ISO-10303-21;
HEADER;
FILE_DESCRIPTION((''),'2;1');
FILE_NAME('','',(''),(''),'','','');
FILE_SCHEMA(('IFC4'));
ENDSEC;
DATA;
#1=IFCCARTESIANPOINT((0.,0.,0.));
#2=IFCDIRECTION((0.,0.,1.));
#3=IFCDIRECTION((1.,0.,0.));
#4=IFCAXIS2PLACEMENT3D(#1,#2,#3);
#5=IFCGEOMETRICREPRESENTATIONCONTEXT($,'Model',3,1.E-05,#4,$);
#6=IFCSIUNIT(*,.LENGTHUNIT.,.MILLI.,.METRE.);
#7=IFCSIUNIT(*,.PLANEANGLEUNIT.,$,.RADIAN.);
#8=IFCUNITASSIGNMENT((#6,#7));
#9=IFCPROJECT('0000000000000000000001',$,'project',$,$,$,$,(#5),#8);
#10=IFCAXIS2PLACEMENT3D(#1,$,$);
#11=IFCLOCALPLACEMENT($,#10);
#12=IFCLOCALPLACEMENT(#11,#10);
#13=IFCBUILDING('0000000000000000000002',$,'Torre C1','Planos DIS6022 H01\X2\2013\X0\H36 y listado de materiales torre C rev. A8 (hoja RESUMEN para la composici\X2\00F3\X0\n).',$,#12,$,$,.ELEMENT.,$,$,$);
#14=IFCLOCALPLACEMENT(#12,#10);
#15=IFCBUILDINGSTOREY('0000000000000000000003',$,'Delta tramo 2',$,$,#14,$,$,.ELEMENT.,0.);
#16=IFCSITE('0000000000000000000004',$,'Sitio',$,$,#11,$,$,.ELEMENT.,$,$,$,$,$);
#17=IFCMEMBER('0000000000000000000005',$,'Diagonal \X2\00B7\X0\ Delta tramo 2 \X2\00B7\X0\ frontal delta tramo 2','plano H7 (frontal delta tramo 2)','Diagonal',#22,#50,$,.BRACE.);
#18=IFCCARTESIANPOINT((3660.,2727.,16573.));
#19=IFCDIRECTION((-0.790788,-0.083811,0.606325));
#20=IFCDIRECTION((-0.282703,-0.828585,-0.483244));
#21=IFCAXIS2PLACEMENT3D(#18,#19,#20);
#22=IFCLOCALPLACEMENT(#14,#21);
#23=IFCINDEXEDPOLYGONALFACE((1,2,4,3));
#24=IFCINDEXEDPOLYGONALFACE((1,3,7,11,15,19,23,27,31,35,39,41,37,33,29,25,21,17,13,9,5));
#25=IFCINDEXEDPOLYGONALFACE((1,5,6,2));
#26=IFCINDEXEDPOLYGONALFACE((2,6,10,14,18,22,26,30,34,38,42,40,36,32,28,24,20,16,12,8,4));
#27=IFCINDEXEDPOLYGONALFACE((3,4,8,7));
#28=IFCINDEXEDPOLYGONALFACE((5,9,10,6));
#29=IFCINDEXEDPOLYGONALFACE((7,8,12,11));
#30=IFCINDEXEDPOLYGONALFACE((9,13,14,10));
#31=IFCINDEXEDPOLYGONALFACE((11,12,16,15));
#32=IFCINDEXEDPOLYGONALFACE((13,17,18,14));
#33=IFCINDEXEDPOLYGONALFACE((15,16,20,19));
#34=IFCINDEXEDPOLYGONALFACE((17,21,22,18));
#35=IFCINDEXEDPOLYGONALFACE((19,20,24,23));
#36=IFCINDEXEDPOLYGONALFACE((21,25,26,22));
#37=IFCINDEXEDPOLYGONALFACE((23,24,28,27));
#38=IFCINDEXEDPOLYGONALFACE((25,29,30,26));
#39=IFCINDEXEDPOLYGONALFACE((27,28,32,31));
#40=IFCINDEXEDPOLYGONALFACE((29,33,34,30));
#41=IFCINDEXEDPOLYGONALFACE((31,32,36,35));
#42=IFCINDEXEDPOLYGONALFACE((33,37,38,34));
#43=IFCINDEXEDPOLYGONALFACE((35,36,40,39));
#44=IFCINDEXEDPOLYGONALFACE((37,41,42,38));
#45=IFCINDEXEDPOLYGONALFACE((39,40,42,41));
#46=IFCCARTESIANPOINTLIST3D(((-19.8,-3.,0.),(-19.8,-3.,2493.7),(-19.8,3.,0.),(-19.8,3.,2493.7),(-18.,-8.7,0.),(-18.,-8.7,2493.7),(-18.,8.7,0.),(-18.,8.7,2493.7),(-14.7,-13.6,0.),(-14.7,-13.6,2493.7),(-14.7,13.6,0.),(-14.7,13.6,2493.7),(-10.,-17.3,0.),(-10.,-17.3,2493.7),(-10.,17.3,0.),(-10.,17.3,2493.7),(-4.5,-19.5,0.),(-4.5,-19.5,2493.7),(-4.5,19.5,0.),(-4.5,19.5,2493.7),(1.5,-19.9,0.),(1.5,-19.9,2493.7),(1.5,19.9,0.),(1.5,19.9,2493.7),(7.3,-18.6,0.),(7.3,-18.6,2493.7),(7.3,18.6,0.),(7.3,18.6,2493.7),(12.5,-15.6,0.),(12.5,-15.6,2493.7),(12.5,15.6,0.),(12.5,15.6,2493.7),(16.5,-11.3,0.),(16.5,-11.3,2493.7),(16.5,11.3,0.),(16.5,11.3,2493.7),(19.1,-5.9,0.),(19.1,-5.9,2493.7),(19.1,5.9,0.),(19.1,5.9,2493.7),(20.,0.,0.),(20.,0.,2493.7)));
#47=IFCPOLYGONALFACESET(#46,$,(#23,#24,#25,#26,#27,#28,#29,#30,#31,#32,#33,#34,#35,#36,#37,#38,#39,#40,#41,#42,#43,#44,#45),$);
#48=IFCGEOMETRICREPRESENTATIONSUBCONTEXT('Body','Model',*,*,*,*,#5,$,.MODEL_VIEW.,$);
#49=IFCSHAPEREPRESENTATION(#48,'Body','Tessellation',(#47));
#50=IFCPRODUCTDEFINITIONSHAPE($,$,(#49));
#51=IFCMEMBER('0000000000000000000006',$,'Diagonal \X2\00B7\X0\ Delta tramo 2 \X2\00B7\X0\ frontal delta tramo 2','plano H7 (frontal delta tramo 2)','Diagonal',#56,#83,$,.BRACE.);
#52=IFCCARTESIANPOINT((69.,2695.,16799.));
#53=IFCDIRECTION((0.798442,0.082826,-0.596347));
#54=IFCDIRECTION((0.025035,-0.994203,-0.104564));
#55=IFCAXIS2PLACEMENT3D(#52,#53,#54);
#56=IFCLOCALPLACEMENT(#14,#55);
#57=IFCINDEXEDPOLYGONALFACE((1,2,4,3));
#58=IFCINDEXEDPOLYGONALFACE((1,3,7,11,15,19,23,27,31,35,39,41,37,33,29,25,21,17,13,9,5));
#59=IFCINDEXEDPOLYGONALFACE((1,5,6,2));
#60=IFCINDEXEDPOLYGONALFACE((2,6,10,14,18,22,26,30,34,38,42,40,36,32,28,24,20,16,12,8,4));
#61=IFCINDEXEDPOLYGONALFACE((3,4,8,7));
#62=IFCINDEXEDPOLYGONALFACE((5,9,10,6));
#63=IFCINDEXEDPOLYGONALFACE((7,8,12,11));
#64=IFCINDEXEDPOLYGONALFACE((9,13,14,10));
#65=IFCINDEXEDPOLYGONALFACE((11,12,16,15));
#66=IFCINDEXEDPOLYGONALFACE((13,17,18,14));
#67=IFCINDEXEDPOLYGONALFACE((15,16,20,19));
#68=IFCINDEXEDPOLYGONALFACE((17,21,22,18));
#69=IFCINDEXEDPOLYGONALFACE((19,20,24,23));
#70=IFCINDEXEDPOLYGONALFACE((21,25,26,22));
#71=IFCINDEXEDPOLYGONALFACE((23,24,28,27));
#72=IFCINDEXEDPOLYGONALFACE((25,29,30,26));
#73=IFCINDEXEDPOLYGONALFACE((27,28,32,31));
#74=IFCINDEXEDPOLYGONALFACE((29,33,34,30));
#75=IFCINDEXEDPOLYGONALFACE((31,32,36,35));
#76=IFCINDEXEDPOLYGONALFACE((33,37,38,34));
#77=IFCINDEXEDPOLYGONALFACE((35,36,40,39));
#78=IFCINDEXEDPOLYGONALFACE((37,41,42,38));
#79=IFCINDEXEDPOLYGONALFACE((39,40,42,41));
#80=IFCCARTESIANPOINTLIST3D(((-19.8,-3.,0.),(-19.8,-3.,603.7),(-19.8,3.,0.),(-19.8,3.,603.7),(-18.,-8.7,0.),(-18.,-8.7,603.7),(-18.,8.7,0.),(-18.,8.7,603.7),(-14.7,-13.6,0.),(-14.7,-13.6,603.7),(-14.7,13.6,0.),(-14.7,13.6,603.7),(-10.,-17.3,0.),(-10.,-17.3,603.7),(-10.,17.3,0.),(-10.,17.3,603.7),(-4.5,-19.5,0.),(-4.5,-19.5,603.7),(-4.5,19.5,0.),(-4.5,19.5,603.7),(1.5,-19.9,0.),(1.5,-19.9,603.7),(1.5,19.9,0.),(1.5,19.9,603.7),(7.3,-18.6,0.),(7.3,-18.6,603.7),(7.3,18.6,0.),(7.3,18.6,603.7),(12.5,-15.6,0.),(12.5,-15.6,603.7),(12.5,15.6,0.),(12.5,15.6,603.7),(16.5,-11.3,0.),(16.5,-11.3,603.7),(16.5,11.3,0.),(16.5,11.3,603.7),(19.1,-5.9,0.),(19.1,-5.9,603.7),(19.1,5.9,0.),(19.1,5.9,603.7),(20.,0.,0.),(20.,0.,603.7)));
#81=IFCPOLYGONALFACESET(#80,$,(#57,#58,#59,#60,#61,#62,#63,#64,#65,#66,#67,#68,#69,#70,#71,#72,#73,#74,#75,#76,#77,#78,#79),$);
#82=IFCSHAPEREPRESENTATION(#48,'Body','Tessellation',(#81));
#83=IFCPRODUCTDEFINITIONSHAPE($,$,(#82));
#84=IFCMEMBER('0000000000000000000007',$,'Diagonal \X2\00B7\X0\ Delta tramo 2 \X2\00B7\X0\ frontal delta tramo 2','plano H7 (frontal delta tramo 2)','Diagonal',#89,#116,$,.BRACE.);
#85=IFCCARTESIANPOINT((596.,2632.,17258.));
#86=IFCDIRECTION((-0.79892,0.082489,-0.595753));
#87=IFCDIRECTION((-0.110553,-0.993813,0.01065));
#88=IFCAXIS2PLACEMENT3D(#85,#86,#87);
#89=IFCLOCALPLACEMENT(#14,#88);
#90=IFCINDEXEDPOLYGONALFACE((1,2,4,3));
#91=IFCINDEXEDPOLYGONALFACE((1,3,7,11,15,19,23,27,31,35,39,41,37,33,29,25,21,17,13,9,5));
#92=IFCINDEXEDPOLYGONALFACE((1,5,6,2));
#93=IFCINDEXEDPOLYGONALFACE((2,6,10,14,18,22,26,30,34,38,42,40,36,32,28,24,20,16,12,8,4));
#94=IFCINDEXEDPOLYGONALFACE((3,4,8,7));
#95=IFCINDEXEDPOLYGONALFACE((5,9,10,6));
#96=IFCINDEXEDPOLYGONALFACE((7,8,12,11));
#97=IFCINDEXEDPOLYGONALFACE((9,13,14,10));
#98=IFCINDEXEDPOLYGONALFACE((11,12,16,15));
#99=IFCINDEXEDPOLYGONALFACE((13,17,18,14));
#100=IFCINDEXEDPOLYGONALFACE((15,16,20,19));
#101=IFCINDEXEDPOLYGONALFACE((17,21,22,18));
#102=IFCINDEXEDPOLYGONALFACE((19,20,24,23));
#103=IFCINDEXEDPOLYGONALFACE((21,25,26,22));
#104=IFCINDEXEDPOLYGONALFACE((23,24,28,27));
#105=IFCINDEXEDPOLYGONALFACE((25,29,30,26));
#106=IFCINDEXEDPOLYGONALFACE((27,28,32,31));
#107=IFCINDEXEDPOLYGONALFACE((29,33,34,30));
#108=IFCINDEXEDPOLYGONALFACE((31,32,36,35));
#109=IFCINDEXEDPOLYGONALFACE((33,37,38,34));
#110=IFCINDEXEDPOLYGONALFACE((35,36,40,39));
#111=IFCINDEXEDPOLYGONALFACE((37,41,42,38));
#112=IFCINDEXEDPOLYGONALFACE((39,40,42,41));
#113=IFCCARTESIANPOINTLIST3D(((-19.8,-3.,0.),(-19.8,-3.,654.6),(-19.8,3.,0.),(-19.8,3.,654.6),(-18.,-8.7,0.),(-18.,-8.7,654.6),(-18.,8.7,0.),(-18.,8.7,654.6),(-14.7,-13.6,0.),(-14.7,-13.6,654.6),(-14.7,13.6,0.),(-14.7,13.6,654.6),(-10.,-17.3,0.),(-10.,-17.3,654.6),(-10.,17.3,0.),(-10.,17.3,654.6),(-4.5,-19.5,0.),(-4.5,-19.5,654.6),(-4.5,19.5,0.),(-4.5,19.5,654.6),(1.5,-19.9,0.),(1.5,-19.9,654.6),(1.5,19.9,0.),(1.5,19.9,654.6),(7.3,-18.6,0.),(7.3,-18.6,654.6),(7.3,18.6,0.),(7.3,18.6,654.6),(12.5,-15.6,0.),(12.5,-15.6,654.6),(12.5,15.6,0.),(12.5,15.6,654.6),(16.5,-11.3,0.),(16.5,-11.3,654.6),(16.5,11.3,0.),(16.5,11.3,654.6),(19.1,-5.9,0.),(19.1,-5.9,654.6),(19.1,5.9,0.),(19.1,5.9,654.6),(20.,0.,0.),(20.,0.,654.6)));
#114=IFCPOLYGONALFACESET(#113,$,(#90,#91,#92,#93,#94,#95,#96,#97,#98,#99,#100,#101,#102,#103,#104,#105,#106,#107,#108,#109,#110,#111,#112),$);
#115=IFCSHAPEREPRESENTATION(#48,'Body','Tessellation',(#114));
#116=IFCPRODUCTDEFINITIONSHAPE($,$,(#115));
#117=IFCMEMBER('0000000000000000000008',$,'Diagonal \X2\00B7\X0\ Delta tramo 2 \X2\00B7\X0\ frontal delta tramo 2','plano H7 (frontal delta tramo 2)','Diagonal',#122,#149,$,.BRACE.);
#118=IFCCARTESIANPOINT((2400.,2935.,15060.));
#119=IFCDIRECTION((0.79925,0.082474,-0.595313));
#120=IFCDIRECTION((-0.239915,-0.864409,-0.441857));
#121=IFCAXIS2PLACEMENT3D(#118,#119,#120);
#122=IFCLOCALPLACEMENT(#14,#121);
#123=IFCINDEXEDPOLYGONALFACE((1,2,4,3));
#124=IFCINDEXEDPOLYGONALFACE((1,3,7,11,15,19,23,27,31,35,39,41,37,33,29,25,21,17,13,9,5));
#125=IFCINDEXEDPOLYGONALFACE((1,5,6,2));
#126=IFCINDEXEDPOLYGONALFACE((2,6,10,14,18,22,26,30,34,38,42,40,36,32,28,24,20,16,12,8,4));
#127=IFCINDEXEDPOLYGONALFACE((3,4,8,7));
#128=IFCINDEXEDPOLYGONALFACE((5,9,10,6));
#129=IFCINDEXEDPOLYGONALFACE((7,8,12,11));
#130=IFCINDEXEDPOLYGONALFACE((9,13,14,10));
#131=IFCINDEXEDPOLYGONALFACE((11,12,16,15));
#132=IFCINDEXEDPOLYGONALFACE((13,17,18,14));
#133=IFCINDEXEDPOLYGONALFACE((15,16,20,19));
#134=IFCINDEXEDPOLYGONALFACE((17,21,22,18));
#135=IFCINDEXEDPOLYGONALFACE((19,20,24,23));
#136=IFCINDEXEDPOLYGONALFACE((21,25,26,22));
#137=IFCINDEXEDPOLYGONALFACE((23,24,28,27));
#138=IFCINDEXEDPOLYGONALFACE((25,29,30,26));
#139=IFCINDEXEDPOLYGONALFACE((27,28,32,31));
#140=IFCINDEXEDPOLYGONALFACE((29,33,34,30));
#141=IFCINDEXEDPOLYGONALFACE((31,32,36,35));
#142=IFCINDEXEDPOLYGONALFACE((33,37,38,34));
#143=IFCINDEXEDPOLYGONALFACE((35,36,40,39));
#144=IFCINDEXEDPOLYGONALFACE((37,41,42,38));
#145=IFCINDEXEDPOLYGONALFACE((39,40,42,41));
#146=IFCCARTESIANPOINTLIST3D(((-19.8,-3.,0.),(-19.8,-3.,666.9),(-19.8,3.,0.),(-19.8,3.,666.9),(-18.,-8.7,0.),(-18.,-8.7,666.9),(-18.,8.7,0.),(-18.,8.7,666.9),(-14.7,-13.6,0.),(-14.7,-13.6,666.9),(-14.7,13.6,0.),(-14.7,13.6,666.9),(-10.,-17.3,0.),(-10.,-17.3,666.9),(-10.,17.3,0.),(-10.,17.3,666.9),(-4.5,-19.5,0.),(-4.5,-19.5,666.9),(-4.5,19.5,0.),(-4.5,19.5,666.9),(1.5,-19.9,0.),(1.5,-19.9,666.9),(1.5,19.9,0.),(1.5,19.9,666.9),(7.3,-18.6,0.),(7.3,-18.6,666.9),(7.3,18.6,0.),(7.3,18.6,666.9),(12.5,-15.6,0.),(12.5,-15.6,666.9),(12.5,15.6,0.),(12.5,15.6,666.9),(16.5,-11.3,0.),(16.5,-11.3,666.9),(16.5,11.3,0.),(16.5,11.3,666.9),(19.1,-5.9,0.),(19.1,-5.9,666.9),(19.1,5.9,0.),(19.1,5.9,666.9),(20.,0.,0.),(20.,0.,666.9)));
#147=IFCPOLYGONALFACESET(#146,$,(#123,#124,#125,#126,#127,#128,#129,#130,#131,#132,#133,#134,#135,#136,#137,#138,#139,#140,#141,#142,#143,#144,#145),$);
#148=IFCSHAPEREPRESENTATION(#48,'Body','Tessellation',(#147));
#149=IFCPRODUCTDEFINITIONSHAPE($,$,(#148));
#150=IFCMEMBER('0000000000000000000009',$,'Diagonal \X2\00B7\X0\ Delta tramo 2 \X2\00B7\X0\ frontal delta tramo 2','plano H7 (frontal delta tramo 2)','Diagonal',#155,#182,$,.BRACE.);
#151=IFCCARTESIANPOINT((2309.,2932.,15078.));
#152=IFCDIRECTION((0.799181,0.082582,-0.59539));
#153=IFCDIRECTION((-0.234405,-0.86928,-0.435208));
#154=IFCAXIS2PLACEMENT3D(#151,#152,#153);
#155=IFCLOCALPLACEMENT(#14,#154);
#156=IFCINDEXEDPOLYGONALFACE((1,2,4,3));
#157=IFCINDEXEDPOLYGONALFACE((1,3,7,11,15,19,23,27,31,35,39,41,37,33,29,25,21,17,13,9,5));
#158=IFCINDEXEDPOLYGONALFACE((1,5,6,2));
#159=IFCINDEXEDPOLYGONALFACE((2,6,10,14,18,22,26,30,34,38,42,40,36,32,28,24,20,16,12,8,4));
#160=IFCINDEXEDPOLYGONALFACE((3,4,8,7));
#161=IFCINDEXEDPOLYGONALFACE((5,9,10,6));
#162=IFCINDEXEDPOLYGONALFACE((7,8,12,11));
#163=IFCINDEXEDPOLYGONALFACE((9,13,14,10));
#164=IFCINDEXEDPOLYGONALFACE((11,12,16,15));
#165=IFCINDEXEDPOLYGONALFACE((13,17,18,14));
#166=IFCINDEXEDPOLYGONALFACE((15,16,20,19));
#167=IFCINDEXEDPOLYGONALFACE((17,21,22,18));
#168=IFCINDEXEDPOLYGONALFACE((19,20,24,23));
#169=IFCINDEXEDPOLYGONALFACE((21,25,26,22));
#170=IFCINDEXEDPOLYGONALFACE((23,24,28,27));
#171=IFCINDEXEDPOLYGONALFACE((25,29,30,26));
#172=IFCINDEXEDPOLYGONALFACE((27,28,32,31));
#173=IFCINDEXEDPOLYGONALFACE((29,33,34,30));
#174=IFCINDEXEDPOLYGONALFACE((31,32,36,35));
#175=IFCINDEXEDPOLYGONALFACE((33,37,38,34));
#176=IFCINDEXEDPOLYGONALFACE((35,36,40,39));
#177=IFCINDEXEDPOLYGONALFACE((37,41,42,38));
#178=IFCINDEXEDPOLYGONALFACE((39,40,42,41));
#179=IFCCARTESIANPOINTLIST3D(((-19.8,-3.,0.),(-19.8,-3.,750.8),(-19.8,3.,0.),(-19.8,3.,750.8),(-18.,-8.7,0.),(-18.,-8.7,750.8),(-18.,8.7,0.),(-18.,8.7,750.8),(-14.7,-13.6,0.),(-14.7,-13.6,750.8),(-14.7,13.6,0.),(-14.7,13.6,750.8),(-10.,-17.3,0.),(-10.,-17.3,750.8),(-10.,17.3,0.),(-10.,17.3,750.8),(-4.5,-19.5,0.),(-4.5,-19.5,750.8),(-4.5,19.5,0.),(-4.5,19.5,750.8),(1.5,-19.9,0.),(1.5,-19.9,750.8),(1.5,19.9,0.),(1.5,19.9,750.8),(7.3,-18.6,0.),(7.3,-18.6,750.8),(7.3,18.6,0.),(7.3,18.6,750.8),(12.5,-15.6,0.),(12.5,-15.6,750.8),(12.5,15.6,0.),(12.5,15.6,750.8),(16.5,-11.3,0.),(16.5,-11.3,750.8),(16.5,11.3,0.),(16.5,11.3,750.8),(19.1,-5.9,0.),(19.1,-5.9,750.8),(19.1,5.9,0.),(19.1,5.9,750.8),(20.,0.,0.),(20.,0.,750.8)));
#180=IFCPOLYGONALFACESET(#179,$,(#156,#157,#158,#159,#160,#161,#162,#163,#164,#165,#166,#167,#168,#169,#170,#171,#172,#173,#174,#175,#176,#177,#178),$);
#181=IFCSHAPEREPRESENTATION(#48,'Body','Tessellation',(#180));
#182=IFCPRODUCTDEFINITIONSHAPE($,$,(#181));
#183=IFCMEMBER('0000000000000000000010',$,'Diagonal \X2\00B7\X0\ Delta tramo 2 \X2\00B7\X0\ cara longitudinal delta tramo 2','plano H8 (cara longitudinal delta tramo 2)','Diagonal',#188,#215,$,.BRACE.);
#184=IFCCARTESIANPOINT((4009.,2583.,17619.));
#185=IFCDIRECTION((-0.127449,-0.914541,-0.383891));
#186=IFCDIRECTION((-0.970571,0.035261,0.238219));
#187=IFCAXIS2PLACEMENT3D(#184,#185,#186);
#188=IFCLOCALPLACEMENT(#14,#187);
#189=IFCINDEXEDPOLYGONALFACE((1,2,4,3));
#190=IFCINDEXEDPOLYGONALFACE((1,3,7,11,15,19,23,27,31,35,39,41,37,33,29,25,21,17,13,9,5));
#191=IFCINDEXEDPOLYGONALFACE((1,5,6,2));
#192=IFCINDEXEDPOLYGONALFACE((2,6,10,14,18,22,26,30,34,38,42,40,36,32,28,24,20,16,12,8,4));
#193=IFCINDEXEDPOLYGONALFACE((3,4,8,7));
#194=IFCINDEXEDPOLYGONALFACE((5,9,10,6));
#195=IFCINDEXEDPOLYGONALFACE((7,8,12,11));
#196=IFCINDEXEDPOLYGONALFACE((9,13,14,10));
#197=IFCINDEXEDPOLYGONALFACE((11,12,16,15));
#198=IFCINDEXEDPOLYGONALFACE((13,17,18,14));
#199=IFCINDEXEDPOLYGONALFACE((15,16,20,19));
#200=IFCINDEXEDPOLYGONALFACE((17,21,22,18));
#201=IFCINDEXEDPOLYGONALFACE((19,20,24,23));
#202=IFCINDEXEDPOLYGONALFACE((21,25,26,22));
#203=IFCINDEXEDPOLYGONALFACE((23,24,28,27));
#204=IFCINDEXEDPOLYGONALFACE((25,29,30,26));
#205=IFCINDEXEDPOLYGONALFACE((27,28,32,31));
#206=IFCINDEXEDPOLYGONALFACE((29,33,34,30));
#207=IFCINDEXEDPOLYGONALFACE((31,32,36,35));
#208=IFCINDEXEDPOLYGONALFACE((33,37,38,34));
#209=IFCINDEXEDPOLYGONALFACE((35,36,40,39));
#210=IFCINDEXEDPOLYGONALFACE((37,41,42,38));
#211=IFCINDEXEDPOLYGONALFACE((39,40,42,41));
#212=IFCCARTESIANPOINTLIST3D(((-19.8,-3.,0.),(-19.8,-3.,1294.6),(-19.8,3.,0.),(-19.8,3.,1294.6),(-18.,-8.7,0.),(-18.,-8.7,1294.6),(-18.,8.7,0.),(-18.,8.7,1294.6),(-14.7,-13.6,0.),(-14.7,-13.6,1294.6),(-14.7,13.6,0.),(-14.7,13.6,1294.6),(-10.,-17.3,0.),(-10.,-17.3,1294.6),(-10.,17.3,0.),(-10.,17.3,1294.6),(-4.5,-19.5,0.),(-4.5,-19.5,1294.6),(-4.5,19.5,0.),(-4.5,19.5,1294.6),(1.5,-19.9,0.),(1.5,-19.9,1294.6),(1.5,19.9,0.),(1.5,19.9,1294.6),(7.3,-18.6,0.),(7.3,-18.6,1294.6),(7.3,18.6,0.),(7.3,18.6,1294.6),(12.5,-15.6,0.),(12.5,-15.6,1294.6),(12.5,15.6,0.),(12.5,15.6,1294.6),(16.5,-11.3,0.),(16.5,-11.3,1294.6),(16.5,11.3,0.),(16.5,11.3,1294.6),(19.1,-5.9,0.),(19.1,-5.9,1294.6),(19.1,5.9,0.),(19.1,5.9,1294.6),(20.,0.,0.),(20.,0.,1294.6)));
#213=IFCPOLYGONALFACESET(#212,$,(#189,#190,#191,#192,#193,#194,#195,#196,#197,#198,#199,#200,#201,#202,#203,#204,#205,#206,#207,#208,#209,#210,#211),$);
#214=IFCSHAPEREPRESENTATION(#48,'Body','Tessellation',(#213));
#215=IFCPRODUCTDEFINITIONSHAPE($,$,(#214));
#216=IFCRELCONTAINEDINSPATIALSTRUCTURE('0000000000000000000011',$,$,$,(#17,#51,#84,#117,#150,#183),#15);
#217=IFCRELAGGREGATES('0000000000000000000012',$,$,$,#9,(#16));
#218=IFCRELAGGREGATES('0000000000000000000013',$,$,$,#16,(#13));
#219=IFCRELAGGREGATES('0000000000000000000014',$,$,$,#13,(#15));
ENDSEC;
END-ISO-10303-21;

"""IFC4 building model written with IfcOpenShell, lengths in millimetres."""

from ifc_helpers import new_model, si_unit, frame, origin, origin_with_axes, place, context, subcontext, project, spatial, circle, extrude, element, save


model = new_model("IFC4")

# Units and contexts
model_context = context("Model", 3, precision=1e-05, world=origin_with_axes())
body_context = subcontext(model_context, "Body", "Model", "MODEL_VIEW")
ifc_project = project(units=[si_unit("LENGTHUNIT", "METRE", prefix="MILLI"), si_unit("PLANEANGLEUNIT", "RADIAN")], contexts=[model_context])

# Site, building, storey
site_placement = place(None, origin())
site = spatial("IfcSite", under=ifc_project, at=site_placement, Name="Sitio", CompositionType="ELEMENT")
building_placement = place(site_placement, origin())
building = spatial("IfcBuilding", under=site, at=building_placement, Name="Torre C1", Description="Planos DIS6022 H01–H36 y listado de materiales torre C rev. A8 (hoja RESUMEN para la composición).", CompositionType="ELEMENT")
storey_placement = place(building_placement, origin())
storey = spatial("IfcBuildingStorey", under=building, at=storey_placement, Name="Delta tramo 2", CompositionType="ELEMENT", Elevation=0.0)

# Members
member_1_placement = place(storey_placement, frame((3660.0, 2727.0, 16573.0), z_axis=(-0.790788, -0.083811, 0.606325), x_axis=(-0.282703, -0.828585, -0.483244)))
element("IfcMember", 1, at=member_1_placement, inside=storey, Name="Diagonal · Delta tramo 2 · frontal delta tramo 2", Description="plano H7 (frontal delta tramo 2)", ObjectType="Diagonal", PredefinedType="BRACE", context=body_context, shape_type="SweptSolid", body=[
    extrude(circle(Radius=20.0), None, (0.0, 0.0, 1.0), 2493.7),
])
member_2_placement = place(storey_placement, frame((69.0, 2695.0, 16799.0), z_axis=(0.798442, 0.082826, -0.596347), x_axis=(0.025035, -0.994203, -0.104564)))
element("IfcMember", 2, at=member_2_placement, inside=storey, Name="Diagonal · Delta tramo 2 · frontal delta tramo 2", Description="plano H7 (frontal delta tramo 2)", ObjectType="Diagonal", PredefinedType="BRACE", context=body_context, shape_type="SweptSolid", body=[
    extrude(circle(Radius=20.0), None, (0.0, 0.0, 1.0), 603.7),
])
member_3_placement = place(storey_placement, frame((596.0, 2632.0, 17258.0), z_axis=(-0.79892, 0.082489, -0.595753), x_axis=(-0.110553, -0.993813, 0.01065)))
element("IfcMember", 3, at=member_3_placement, inside=storey, Name="Diagonal · Delta tramo 2 · frontal delta tramo 2", Description="plano H7 (frontal delta tramo 2)", ObjectType="Diagonal", PredefinedType="BRACE", context=body_context, shape_type="SweptSolid", body=[
    extrude(circle(Radius=20.0), None, (0.0, 0.0, 1.0), 654.6),
])
member_4_placement = place(storey_placement, frame((2400.0, 2935.0, 15060.0), z_axis=(0.79925, 0.082474, -0.595313), x_axis=(-0.239915, -0.864409, -0.441857)))
element("IfcMember", 4, at=member_4_placement, inside=storey, Name="Diagonal · Delta tramo 2 · frontal delta tramo 2", Description="plano H7 (frontal delta tramo 2)", ObjectType="Diagonal", PredefinedType="BRACE", context=body_context, shape_type="SweptSolid", body=[
    extrude(circle(Radius=20.0), None, (0.0, 0.0, 1.0), 666.9),
])
member_5_placement = place(storey_placement, frame((2309.0, 2932.0, 15078.0), z_axis=(0.799181, 0.082582, -0.59539), x_axis=(-0.234405, -0.86928, -0.435208)))
element("IfcMember", 5, at=member_5_placement, inside=storey, Name="Diagonal · Delta tramo 2 · frontal delta tramo 2", Description="plano H7 (frontal delta tramo 2)", ObjectType="Diagonal", PredefinedType="BRACE", context=body_context, shape_type="SweptSolid", body=[
    extrude(circle(Radius=20.0), None, (0.0, 0.0, 1.0), 750.8),
])
member_6_placement = place(storey_placement, frame((4009.0, 2583.0, 17619.0), z_axis=(-0.127449, -0.914541, -0.383891), x_axis=(-0.970571, 0.035261, 0.238219)))
element("IfcMember", 6, at=member_6_placement, inside=storey, Name="Diagonal · Delta tramo 2 · cara longitudinal delta tramo 2", Description="plano H8 (cara longitudinal delta tramo 2)", ObjectType="Diagonal", PredefinedType="BRACE", context=body_context, shape_type="SweptSolid", body=[
    extrude(circle(Radius=20.0), None, (0.0, 0.0, 1.0), 1294.6),
])

save(model, "model.ifc")
